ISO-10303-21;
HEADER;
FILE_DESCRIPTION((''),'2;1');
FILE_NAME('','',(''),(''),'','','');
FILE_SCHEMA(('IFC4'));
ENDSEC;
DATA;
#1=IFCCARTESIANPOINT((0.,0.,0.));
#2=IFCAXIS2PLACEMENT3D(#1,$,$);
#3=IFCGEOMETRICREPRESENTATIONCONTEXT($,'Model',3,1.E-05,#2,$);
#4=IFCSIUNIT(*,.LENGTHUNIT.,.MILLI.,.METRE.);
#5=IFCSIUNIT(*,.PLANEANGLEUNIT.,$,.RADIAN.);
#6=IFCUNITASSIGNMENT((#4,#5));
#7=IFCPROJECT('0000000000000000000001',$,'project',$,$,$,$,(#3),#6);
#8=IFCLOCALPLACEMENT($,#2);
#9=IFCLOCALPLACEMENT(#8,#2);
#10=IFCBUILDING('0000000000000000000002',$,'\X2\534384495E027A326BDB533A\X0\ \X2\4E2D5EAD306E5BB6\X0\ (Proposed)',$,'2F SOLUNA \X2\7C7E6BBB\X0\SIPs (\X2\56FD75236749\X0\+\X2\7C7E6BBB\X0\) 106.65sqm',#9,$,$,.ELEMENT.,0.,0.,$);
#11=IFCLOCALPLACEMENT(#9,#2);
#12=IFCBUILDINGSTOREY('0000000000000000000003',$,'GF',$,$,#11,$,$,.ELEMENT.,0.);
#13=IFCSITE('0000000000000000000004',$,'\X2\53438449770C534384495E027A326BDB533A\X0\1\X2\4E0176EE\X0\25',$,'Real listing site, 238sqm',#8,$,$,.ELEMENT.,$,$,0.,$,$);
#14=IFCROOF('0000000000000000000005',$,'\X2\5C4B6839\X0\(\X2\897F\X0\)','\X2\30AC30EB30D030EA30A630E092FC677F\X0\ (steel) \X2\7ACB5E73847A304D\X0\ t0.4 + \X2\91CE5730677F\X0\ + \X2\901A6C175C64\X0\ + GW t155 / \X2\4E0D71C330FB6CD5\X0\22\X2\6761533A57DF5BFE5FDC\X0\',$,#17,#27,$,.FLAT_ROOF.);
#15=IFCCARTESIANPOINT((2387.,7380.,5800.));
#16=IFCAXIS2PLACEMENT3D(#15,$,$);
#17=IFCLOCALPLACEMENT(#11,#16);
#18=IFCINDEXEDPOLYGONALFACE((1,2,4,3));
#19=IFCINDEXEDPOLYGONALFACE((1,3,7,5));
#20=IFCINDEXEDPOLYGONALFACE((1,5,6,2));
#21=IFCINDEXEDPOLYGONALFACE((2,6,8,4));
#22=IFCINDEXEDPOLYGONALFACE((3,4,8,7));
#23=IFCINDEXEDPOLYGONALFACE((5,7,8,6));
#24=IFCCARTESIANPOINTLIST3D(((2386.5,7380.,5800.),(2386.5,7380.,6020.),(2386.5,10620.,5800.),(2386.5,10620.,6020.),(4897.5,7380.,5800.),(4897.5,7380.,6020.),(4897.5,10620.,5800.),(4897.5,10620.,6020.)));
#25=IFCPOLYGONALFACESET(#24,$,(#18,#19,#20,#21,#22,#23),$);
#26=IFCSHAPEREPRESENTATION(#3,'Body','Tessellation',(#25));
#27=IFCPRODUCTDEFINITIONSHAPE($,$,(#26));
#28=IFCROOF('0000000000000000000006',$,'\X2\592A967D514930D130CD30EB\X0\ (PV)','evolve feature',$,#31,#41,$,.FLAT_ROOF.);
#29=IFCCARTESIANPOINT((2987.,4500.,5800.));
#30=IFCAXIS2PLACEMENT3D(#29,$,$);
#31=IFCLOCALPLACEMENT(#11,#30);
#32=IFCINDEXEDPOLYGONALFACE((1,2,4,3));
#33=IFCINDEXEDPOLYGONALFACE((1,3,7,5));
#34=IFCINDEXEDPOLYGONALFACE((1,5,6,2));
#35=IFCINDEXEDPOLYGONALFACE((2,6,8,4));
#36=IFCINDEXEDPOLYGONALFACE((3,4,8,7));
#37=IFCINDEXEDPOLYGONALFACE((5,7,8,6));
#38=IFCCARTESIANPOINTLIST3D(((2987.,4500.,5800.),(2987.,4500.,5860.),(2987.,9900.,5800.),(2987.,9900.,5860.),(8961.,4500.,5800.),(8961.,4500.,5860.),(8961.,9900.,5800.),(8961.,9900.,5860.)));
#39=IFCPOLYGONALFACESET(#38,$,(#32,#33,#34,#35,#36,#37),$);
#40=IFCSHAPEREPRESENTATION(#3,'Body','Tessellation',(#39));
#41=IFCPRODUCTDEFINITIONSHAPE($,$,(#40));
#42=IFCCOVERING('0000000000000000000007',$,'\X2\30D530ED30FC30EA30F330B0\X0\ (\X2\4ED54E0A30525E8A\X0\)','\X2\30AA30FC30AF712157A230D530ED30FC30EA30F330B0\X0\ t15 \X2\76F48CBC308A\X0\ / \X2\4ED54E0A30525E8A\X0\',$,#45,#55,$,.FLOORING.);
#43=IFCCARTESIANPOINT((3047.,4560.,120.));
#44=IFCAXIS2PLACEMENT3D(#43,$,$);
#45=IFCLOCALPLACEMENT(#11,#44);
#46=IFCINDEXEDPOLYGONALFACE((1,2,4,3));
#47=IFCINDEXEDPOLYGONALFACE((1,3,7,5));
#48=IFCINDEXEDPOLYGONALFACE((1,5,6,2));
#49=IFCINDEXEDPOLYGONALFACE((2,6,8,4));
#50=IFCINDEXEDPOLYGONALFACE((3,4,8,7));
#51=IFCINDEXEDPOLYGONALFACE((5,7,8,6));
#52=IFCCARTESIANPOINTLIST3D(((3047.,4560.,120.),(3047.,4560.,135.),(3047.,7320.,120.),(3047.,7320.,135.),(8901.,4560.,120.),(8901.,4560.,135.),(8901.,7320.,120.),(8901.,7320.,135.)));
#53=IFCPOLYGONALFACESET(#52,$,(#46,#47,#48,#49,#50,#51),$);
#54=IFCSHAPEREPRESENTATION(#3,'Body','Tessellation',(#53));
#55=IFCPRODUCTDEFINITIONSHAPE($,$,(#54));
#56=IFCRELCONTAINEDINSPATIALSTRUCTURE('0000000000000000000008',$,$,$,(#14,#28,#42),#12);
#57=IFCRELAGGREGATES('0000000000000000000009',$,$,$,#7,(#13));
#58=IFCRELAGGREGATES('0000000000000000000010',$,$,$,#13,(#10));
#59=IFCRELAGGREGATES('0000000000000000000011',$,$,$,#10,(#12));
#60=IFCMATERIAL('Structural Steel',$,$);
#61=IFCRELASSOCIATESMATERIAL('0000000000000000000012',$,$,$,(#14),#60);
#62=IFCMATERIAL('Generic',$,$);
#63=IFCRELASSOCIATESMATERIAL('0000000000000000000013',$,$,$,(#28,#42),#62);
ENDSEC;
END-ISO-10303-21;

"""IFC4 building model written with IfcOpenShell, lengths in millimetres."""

from ifc_helpers import new_model, si_unit, frame, frame_2d, origin, place, context, project, spatial, rectangle, extrude, material, element, save


model = new_model("IFC4")

# Units and contexts
model_context = context("Model", 3, precision=1e-05, world=origin())
ifc_project = project(units=[si_unit("LENGTHUNIT", "METRE", prefix="MILLI"), si_unit("PLANEANGLEUNIT", "RADIAN")], contexts=[model_context])

# Site, building, storey
site_placement = place(None, origin())
site = spatial("IfcSite", under=ifc_project, at=site_placement, Name="千葉県千葉市稲毛区1丁目25", ObjectType="Real listing site, 238sqm", CompositionType="ELEMENT", RefElevation=0.0)
building_placement = place(site_placement, origin())
building = spatial("IfcBuilding", under=site, at=building_placement, Name="千葉市稲毛区 中庭の家 (Proposed)", ObjectType="2F SOLUNA 籾殻SIPs (国産杉+籾殻) 106.65sqm", CompositionType="ELEMENT", ElevationOfRefHeight=0.0, ElevationOfTerrain=0.0)
storey_placement = place(building_placement, origin())
storey = spatial("IfcBuildingStorey", under=building, at=storey_placement, Name="GF", CompositionType="ELEMENT", Elevation=0.0)

# Shared definitions
ifc_material_1 = material(Name="Generic")

# Roofs
ifc_material_2 = material(Name="Structural Steel")
roof_1_placement = place(storey_placement, frame((2387.0, 7380.0, 5800.0)))
element("IfcRoof", 1, at=roof_1_placement, inside=storey, material=ifc_material_2, Name="屋根(西)", Description="ガルバリウム鋼板 (steel) 立平葺き t0.4 + 野地板 + 通気層 + GW t155 / 不燃・法22条区域対応", PredefinedType="FLAT_ROOF", context=model_context, shape_type="SweptSolid", body=[
    extrude(rectangle(XDim=2511.0, YDim=3240.0, at=frame_2d((1255.0, 1620.0))), frame((2387.0, 7380.0, 5800.0)), (0.0, 0.0, 1.0), 220.0),
])
roof_2_placement = place(storey_placement, frame((2987.0, 4500.0, 5800.0)))
element("IfcRoof", 2, at=roof_2_placement, inside=storey, material=ifc_material_1, Name="太陽光パネル (PV)", Description="evolve feature", PredefinedType="FLAT_ROOF", context=model_context, shape_type="SweptSolid", body=[
    extrude(rectangle(XDim=5974.0, YDim=5400.0, at=frame_2d((2987.0, 2700.0))), frame((2987.0, 4500.0, 5800.0)), (0.0, 0.0, 1.0), 60.0),
])

# Covering
covering_placement = place(storey_placement, frame((3047.0, 4560.0, 120.0)))
element("IfcCovering", 3, at=covering_placement, inside=storey, material=ifc_material_1, Name="フローリング (仕上げ床)", Description="オーク無垢フローリング t15 直貼り / 仕上げ床", PredefinedType="FLOORING", context=model_context, shape_type="SweptSolid", body=[
    extrude(rectangle(XDim=5854.0, YDim=2760.0, at=frame_2d((2927.0, 1380.0))), frame((3047.0, 4560.0, 120.0)), (0.0, 0.0, 1.0), 15.0),
])

save(model, "model.ifc")
